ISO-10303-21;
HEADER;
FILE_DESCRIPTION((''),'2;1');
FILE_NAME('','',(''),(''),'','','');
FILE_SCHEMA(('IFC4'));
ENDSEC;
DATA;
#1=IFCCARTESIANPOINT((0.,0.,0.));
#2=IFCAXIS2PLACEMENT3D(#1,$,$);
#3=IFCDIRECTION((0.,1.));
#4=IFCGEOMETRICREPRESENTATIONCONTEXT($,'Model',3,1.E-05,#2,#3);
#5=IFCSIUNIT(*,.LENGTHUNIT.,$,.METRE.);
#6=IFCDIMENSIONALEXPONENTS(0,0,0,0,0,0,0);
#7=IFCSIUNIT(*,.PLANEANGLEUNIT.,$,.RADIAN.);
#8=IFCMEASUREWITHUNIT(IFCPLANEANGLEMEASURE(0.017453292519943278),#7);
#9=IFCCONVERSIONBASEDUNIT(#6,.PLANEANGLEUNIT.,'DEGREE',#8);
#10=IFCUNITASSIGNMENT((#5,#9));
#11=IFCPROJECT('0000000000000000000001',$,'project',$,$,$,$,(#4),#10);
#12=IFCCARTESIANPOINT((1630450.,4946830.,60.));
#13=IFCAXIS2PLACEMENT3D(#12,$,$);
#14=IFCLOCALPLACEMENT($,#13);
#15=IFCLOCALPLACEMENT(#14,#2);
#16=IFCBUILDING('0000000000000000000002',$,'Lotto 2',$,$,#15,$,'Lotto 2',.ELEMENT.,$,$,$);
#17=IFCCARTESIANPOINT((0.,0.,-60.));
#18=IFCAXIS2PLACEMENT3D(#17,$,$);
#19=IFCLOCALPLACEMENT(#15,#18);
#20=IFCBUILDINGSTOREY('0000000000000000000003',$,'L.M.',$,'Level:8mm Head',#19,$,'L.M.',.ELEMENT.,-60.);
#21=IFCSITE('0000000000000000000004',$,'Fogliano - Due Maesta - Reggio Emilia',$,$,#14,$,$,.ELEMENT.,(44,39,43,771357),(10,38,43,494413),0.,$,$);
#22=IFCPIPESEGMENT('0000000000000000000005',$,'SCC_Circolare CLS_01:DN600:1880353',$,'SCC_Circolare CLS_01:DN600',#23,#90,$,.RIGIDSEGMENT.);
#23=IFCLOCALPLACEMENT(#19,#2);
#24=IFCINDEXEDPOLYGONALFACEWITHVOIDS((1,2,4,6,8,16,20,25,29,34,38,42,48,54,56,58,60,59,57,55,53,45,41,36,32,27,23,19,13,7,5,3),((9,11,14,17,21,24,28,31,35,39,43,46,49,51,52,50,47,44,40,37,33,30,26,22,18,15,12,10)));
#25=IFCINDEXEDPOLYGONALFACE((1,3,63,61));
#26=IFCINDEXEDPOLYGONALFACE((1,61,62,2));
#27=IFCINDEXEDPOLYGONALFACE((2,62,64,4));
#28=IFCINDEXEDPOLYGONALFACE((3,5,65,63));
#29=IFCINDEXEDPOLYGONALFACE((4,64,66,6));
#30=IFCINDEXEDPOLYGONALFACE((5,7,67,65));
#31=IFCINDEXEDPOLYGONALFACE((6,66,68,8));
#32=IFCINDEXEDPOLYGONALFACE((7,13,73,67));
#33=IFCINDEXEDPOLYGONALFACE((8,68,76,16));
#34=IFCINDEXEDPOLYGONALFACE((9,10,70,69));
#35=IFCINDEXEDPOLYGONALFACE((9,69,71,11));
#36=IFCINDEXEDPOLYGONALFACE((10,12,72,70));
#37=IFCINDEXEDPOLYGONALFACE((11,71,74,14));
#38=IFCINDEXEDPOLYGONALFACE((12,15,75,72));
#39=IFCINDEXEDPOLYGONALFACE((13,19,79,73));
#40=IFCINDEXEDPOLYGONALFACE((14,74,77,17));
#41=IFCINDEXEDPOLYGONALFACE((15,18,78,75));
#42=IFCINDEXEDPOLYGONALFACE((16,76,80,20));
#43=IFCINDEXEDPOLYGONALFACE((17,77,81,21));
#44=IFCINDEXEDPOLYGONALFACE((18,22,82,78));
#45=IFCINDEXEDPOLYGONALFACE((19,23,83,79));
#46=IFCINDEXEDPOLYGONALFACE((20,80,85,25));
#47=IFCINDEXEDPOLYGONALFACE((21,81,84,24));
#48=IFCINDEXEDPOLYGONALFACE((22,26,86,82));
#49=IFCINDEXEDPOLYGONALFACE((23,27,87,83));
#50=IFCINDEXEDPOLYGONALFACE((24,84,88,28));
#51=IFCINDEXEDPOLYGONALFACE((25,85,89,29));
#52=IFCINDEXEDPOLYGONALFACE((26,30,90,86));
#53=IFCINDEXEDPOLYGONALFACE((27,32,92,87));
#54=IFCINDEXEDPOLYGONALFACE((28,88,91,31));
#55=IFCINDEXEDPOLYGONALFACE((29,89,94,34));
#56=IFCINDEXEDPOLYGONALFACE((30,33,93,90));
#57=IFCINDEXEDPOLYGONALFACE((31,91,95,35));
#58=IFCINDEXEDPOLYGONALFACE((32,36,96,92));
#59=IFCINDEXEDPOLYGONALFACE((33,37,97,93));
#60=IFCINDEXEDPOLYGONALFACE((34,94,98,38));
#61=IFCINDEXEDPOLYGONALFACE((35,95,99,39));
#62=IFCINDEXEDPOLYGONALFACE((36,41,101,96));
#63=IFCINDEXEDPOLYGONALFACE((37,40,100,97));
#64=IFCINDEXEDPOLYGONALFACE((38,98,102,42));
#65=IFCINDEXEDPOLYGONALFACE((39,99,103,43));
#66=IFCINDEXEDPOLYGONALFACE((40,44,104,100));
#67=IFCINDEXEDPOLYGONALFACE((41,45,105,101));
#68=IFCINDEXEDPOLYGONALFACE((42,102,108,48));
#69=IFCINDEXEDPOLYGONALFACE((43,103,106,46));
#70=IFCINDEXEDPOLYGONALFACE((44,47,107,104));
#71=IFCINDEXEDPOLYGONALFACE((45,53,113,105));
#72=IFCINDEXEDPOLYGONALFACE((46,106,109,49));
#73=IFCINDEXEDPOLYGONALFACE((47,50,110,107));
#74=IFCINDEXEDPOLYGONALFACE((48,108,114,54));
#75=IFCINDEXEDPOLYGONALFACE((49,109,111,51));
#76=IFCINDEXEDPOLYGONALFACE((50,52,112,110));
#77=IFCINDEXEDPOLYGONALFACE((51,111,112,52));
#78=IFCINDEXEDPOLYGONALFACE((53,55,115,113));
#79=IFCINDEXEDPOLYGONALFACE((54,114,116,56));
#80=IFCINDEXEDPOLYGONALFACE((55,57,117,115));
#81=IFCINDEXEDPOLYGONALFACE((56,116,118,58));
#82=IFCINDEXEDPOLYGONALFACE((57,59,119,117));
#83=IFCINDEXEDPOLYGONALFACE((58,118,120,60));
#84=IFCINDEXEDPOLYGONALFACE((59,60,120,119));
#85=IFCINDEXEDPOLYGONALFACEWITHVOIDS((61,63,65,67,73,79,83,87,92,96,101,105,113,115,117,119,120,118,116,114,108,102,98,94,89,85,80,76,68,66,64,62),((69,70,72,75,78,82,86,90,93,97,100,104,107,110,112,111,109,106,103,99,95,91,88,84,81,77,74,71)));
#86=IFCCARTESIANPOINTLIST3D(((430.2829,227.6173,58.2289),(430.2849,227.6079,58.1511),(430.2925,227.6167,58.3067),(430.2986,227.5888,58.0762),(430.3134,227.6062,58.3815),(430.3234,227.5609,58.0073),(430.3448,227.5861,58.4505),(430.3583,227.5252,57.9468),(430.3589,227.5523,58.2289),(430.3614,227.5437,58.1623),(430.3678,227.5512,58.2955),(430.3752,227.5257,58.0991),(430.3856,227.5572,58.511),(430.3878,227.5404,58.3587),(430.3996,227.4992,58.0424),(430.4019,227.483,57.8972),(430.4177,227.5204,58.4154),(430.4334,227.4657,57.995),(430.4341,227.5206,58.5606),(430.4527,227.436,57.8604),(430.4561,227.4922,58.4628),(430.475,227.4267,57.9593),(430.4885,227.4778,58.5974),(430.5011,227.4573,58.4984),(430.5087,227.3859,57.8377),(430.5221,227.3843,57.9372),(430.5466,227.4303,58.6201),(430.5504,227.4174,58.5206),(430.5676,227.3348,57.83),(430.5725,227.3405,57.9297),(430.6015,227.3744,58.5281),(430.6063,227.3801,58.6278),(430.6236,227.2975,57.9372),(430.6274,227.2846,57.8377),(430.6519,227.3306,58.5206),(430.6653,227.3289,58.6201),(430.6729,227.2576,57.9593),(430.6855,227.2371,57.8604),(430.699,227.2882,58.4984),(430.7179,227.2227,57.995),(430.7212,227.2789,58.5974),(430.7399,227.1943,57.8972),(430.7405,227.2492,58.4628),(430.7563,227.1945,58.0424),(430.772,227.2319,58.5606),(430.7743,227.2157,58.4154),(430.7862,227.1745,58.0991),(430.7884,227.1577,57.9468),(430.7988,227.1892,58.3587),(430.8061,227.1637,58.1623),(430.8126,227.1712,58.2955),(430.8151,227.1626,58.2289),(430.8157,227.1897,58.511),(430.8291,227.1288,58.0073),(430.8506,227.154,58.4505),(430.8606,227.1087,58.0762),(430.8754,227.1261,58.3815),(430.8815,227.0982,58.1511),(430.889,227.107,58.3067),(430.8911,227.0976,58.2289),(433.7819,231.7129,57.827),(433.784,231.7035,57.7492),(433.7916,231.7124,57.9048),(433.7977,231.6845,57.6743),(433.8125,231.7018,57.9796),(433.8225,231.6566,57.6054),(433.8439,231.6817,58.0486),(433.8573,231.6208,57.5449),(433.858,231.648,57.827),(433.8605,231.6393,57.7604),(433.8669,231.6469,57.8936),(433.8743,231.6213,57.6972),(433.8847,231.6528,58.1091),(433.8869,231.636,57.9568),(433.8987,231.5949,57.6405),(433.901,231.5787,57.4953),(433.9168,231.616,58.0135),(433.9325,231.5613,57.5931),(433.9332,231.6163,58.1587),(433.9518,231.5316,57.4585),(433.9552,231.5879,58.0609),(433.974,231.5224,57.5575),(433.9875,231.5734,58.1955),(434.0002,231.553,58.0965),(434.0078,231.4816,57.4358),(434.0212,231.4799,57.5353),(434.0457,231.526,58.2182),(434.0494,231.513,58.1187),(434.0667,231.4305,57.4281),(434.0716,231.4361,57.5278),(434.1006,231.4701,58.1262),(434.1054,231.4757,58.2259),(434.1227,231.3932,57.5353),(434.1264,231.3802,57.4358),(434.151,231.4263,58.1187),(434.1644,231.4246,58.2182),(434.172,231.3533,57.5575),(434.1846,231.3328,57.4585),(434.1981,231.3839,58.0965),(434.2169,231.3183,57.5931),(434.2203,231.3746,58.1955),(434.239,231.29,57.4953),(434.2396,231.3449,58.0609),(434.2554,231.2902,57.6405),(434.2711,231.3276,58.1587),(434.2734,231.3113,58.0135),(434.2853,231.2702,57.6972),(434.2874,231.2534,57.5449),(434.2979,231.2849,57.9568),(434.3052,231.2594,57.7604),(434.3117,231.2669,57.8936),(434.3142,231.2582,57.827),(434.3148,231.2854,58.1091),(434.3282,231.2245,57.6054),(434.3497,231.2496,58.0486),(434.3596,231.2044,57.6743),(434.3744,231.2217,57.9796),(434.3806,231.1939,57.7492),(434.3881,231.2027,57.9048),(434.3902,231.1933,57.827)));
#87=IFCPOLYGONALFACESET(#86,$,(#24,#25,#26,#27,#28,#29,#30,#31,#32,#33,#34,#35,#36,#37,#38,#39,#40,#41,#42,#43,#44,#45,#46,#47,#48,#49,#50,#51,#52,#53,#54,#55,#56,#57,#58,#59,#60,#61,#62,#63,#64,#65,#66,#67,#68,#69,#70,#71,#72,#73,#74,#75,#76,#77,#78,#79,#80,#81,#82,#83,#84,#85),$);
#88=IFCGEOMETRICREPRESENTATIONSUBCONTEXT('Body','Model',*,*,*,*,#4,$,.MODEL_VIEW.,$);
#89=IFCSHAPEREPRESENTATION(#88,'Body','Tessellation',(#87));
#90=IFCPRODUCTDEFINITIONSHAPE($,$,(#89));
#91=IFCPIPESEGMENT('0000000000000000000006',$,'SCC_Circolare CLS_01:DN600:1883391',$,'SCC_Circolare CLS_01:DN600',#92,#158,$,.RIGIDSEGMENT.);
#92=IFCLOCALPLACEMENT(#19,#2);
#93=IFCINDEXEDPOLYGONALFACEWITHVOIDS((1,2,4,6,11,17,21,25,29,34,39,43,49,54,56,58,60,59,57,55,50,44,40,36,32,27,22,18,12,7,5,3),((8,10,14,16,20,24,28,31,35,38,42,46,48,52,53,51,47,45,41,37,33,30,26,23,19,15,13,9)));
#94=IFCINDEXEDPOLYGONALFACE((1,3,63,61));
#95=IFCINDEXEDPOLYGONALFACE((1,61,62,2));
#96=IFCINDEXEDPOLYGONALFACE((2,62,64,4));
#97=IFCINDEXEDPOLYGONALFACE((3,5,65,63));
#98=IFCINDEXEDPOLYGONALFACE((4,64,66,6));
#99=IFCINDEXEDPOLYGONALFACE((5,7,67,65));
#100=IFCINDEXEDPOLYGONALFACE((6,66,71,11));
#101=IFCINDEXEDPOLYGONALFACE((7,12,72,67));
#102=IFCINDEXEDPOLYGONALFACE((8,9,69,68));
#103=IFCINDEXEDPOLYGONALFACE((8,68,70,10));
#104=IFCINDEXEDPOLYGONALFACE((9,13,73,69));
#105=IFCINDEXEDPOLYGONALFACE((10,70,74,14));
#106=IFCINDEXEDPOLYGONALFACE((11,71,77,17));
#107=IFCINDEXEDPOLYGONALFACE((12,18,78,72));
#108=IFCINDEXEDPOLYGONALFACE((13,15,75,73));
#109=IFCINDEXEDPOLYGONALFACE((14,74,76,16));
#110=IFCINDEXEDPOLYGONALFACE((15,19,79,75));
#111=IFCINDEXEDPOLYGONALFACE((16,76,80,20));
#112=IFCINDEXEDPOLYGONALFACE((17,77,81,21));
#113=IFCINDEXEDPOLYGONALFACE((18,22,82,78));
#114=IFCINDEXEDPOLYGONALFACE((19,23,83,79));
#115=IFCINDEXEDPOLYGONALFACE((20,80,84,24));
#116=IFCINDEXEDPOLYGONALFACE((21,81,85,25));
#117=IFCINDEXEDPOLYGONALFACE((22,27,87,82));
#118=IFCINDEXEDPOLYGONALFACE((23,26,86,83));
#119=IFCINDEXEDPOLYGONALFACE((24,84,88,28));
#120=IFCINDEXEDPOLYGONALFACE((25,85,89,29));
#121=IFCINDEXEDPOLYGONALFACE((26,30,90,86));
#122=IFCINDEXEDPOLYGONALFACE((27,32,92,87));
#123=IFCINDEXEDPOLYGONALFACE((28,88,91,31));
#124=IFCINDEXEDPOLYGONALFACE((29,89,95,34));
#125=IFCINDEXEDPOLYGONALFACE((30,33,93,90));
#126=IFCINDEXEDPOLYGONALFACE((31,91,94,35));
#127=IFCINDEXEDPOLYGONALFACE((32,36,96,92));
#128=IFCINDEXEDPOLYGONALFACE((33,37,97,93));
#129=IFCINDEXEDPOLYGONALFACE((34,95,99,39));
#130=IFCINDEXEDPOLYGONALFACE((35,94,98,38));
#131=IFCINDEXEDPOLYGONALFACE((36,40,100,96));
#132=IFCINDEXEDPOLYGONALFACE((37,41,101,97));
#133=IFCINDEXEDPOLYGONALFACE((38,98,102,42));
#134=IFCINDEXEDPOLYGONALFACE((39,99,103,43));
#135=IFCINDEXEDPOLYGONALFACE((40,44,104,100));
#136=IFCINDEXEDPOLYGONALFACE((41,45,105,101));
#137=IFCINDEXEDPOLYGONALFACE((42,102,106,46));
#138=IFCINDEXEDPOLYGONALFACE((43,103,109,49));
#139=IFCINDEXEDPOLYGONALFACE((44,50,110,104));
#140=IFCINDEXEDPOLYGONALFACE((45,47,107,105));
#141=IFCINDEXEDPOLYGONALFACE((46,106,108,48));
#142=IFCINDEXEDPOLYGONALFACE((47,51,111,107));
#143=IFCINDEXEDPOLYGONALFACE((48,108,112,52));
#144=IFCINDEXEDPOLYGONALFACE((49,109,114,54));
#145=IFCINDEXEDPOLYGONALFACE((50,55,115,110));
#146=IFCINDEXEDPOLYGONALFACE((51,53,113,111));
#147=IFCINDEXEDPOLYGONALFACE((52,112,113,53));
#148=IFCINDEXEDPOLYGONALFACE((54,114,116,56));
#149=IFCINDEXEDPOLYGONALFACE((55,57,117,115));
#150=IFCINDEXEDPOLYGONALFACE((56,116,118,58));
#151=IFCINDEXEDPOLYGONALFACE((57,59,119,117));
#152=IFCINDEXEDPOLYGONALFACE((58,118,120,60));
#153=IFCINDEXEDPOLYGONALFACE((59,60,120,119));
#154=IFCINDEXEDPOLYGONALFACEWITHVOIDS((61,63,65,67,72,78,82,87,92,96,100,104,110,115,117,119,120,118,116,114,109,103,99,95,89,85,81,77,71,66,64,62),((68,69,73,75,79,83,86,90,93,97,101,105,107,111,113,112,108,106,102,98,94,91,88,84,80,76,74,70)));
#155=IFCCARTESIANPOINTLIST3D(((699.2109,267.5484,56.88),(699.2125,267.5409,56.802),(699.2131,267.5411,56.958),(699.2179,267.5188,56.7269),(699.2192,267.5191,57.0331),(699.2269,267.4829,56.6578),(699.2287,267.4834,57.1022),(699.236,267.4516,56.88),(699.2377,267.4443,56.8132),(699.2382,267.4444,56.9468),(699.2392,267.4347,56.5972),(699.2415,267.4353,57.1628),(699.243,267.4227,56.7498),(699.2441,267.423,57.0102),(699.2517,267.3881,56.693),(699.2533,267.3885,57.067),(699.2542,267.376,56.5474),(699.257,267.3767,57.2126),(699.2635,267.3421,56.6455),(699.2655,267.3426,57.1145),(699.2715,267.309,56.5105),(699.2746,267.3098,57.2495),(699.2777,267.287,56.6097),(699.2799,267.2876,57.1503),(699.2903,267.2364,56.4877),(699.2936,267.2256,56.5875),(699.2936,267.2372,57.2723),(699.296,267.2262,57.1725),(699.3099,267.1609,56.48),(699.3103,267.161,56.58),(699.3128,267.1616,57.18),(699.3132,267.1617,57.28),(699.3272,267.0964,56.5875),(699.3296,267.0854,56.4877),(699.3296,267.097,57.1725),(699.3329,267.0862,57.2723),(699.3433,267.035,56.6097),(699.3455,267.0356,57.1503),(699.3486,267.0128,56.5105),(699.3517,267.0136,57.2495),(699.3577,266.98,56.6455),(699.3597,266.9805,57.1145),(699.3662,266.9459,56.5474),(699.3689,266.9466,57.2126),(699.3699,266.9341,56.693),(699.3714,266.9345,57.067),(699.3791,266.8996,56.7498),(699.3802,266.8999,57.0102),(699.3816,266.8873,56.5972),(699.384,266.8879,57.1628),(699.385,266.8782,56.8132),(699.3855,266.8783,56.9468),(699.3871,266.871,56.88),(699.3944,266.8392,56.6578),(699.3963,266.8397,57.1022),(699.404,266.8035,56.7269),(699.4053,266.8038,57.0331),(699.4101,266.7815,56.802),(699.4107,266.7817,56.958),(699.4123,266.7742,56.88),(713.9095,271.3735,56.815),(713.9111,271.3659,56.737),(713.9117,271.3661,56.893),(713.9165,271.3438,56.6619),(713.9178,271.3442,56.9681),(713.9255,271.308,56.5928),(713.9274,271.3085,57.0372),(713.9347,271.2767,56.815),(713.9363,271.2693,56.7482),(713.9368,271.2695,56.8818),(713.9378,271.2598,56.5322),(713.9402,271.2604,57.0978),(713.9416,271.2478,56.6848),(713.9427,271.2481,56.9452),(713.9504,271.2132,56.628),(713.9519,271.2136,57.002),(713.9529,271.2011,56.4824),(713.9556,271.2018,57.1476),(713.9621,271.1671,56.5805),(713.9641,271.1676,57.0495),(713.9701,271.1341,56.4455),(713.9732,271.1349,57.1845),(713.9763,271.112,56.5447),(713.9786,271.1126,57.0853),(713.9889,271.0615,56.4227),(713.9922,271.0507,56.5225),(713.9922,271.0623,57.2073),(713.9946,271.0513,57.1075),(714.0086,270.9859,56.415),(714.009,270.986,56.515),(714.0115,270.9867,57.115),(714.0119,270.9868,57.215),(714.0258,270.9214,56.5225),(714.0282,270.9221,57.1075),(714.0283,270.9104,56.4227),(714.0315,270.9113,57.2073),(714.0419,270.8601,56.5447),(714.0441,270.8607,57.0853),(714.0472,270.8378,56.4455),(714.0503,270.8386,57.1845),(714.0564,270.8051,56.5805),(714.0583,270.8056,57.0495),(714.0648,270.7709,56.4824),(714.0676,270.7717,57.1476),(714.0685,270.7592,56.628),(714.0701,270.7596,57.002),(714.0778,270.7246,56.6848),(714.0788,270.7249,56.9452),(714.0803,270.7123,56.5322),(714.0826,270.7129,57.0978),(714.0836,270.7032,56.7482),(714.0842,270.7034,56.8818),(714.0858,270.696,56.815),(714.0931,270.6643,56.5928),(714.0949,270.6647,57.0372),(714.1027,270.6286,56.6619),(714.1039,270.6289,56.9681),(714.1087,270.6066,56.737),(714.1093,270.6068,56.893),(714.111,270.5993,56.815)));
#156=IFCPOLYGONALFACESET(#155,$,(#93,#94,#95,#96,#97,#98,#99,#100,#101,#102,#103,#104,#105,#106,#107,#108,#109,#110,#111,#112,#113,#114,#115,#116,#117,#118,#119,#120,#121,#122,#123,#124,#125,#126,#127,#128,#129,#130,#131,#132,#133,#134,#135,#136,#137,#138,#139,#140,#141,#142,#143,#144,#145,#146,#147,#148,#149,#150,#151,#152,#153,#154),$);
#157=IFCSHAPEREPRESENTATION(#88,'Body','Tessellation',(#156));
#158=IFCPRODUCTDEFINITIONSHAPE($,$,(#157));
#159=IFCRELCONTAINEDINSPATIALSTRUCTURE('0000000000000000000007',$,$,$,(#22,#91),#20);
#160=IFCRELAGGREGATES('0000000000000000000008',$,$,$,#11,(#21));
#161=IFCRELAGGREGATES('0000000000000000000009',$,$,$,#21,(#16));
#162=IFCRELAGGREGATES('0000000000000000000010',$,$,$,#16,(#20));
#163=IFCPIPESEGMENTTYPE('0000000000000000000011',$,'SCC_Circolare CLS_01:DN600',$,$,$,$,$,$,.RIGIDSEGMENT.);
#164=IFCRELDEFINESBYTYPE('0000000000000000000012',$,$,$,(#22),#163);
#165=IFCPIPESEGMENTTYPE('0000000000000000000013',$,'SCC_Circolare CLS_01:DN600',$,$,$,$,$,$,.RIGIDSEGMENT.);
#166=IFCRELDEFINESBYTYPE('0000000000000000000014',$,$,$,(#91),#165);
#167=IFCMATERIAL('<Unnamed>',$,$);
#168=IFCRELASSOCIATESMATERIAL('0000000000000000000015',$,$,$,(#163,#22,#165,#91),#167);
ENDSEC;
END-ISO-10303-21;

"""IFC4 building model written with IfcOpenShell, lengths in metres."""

from ifc_helpers import new_model, entity, si_unit, converted_unit, direction, frame, origin, place, context, subcontext, project, spatial, arc, indexed_curve, outline, extrude, source, transform, mapped, material, type_object, type_shapes, element, save


model = new_model("IFC4")

# Units and contexts
model_context = context("Model", 3, precision=1e-05, world=origin(), true_north=direction((0.0, 1.0)))
body_context = subcontext(model_context, "Body", "Model", "MODEL_VIEW")
ifc_project = project(units=[si_unit("LENGTHUNIT", "METRE"), converted_unit("PLANEANGLEUNIT", "DEGREE", entity("IfcPlaneAngleMeasure", 0.017453292519943278), si_unit("PLANEANGLEUNIT", "RADIAN"), dimensions=[0, 0, 0, 0, 0, 0, 0])], contexts=[model_context])

# Site, building, storey
site_placement = place(None, frame((1630450.0, 4946830.0, 60.0)))
site = spatial("IfcSite", under=ifc_project, at=site_placement, Name="Fogliano - Due Maesta - Reggio Emilia", CompositionType="ELEMENT", RefLatitude=(44, 39, 43, 771357), RefLongitude=(10, 38, 43, 494413), RefElevation=0.0)
building_placement = place(site_placement, origin())
building = spatial("IfcBuilding", under=site, at=building_placement, Name="Lotto 2", LongName="Lotto 2", CompositionType="ELEMENT")
storey_placement = place(building_placement, frame((0.0, 0.0, -60.0)))
storey = spatial("IfcBuildingStorey", under=building, at=storey_placement, Name="L.M.", ObjectType="Level:8mm Head", LongName="L.M.", CompositionType="ELEMENT", Elevation=-60.0)

# Pipe segments
ifc_material_1 = material(Name="<Unnamed>")
pipe_segment_type_1 = type_object("IfcPipeSegmentType", Name="SCC_Circolare CLS_01:DN600", PredefinedType="RIGIDSEGMENT", material=ifc_material_1)
shared_shape_1 = source(origin(), body_context, "Body", "SweptSolid", [
    extrude(outline(indexed_curve([(0.0, -0.4), (0.4, 0.0), (0.0, 0.4), (-0.4, 0.0)], segments=[arc(1, 2, 3), arc(3, 4, 1)], self_intersect=False), holes=[indexed_curve([(0.0, -0.3), (-0.3, 0.0), (0.0, 0.3), (0.3, 0.0)], segments=[arc(1, 2, 3), arc(3, 4, 1)], self_intersect=False)]), frame((-2.7009, 0.0, 0.0), z_axis=(1.0, 0.0, 0.0), x_axis=(0.0, 0.0, -1.0)), (0.0, 0.0, 1.0), 5.4018),
])
type_shapes(pipe_segment_type_1, [shared_shape_1])
pipe_segment_1_placement = place(storey_placement, frame((432.3365, 229.4053, 58.0279), z_axis=(0.048328, 0.056567, 0.997228), x_axis=(-0.647761, -0.758202, 0.074401)))
element("IfcPipeSegment", 1, at=pipe_segment_1_placement, inside=storey, type_object=pipe_segment_type_1, material=ifc_material_1, Name="SCC_Circolare CLS_01:DN600:1880353", ObjectType="SCC_Circolare CLS_01:DN600", PredefinedType="RIGIDSEGMENT", context=body_context, shape_type="MappedRepresentation", body=[
    mapped(shared_shape_1, transform((0.0, 0.0, 0.0), scale=1.0)),
])
pipe_segment_type_2 = type_object("IfcPipeSegmentType", Name="SCC_Circolare CLS_01:DN600", PredefinedType="RIGIDSEGMENT", material=ifc_material_1)
shared_shape_2 = source(origin(), body_context, "Body", "SweptSolid", [
    extrude(outline(indexed_curve([(0.0, -0.4), (0.4, 0.0), (0.0, 0.4), (-0.4, 0.0)], segments=[arc(1, 2, 3), arc(3, 4, 1)], self_intersect=False), holes=[indexed_curve([(0.0, -0.3), (-0.3, 0.0), (0.0, 0.3), (0.3, 0.0)], segments=[arc(1, 2, 3), arc(3, 4, 1)], self_intersect=False)]), frame((-7.5942, 0.0, 0.0), z_axis=(1.0, 0.0, 0.0), x_axis=(0.0, 0.0, -1.0)), (0.0, 0.0, 1.0), 15.1883),
])
type_shapes(pipe_segment_type_2, [shared_shape_2])
pipe_segment_2_placement = place(storey_placement, frame((706.6609, 269.0738, 56.8475), z_axis=(0.004142, 0.001078, 0.999991), x_axis=(0.967759, 0.251842, -0.00428)))
element("IfcPipeSegment", 2, at=pipe_segment_2_placement, inside=storey, type_object=pipe_segment_type_2, material=ifc_material_1, Name="SCC_Circolare CLS_01:DN600:1883391", ObjectType="SCC_Circolare CLS_01:DN600", PredefinedType="RIGIDSEGMENT", context=body_context, shape_type="MappedRepresentation", body=[
    mapped(shared_shape_2, transform((0.0, 0.0, 0.0), scale=1.0)),
])

save(model, "model.ifc")
